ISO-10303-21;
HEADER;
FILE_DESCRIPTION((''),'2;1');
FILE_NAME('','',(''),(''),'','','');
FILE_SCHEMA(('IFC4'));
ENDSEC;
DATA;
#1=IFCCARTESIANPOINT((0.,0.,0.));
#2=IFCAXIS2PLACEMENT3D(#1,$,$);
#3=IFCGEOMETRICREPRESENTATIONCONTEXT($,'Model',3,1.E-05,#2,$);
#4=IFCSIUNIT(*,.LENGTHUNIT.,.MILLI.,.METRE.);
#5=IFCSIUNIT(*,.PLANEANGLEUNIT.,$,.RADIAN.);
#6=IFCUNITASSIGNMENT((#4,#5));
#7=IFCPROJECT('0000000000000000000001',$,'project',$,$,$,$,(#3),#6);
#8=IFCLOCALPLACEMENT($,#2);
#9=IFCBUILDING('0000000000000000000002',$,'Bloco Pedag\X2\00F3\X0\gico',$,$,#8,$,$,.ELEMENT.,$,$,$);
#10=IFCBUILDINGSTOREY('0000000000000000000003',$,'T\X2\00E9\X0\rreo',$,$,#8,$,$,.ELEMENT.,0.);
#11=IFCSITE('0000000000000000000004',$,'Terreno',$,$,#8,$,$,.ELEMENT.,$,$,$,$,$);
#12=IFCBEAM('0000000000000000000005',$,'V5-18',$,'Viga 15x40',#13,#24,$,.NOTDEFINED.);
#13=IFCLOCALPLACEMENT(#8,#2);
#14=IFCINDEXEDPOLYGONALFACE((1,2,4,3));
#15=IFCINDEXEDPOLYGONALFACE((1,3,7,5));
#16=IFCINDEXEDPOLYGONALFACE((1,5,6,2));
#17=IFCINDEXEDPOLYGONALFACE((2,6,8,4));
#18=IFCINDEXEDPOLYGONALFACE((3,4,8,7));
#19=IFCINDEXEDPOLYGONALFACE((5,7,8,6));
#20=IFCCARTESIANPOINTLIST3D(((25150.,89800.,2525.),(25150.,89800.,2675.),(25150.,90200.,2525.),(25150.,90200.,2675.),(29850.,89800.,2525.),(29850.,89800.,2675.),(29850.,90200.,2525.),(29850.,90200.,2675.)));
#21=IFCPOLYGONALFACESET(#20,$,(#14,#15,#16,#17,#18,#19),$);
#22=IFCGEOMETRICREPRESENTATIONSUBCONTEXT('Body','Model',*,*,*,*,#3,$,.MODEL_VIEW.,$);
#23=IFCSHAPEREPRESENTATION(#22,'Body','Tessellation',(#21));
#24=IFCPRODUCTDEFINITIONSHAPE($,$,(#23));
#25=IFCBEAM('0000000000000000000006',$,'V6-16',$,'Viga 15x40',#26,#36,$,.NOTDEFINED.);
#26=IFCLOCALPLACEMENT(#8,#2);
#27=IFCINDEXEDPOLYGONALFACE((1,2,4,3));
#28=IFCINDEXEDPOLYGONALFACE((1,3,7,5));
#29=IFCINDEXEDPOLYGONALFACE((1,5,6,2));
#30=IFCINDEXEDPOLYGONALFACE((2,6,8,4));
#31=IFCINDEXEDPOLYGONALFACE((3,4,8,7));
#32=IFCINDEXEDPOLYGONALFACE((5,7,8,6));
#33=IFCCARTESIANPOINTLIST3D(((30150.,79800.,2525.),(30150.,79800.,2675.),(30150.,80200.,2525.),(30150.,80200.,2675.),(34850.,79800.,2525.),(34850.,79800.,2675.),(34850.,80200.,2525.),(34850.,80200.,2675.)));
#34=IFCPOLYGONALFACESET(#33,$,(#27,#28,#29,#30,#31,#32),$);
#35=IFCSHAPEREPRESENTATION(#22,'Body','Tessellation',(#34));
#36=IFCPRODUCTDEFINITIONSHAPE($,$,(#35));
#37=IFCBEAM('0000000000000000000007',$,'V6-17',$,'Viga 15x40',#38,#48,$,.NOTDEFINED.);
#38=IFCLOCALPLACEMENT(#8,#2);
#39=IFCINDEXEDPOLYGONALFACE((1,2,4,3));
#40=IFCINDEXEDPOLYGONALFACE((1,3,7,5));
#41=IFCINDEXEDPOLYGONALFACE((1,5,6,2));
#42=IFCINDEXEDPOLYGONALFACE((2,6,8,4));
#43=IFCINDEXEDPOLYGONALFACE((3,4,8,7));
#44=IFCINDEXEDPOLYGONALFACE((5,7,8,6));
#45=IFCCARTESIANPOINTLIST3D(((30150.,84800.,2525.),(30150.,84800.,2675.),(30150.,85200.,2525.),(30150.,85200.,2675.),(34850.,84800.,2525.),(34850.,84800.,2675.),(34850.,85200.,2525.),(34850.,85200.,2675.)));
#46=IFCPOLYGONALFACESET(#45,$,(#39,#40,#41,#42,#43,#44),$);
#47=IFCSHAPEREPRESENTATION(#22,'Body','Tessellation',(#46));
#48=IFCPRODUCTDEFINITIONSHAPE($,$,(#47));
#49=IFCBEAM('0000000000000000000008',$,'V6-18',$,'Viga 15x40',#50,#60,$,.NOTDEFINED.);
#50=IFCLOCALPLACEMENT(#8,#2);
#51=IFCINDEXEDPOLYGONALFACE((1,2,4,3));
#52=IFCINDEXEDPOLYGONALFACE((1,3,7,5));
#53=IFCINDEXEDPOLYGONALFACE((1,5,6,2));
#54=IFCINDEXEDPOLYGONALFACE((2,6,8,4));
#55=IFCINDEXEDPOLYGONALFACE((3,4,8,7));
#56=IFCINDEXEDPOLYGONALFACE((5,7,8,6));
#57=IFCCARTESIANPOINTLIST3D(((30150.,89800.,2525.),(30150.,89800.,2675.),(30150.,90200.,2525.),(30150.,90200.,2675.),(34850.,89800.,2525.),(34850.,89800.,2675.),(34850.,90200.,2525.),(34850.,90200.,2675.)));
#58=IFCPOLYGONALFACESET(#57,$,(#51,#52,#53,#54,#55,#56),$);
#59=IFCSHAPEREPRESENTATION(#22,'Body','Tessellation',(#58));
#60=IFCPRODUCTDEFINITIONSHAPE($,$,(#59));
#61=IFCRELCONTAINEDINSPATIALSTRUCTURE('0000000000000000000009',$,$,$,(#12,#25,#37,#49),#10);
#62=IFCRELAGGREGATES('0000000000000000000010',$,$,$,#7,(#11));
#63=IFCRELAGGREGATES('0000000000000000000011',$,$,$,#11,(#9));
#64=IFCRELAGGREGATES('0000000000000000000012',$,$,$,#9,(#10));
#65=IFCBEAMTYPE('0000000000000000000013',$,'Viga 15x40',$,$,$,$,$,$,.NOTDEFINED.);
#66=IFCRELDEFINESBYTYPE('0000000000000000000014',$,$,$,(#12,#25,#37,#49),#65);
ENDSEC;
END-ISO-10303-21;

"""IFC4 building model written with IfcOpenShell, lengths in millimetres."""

from ifc_helpers import new_model, si_unit, frame, origin, origin_2d, place, context, subcontext, project, spatial, rectangle, extrude, type_object, element, save


model = new_model("IFC4")

# Units and contexts
model_context = context("Model", 3, precision=1e-05, world=origin())
body_context = subcontext(model_context, "Body", "Model", "MODEL_VIEW")
ifc_project = project(units=[si_unit("LENGTHUNIT", "METRE", prefix="MILLI"), si_unit("PLANEANGLEUNIT", "RADIAN")], contexts=[model_context])

# Site, building, storey
placement = place(None, origin())
site = spatial("IfcSite", under=ifc_project, at=placement, Name="Terreno", CompositionType="ELEMENT")
building = spatial("IfcBuilding", under=site, at=placement, Name="Bloco Pedagógico", CompositionType="ELEMENT")
storey = spatial("IfcBuildingStorey", under=building, at=placement, Name="Térreo", CompositionType="ELEMENT", Elevation=0.0)

# Beams
beam_type = type_object("IfcBeamType", Name="Viga 15x40", PredefinedType="NOTDEFINED")
for number, where, z_axis, x_axis, name in (
    (1, (25150.0, 90000.0, 2600.0), (1.0, 0.0, 0.0), (0.0, 1.0, 0.0), "V5-18"),
    (2, (30150.0, 80000.0, 2600.0), (1.0, 0.0, 0.0), (0.0, 1.0, 0.0), "V6-16"),
    (3, (30150.0, 85000.0, 2600.0), (1.0, 0.0, 0.0), (0.0, 1.0, 0.0), "V6-17"),
    (4, (30150.0, 90000.0, 2600.0), (1.0, 0.0, 0.0), (0.0, 1.0, 0.0), "V6-18"),
):
    element("IfcBeam", number, at=place(None, frame(where, z_axis=z_axis, x_axis=x_axis)), inside=storey, type_object=beam_type, Name=name, ObjectType="Viga 15x40", PredefinedType="NOTDEFINED", context=body_context, shape_type="SweptSolid", body=[
        extrude(rectangle(XDim=400.0, YDim=150.0, at=origin_2d()), None, (0.0, 0.0, 1.0), 4700.0),
    ])

save(model, "model.ifc")
